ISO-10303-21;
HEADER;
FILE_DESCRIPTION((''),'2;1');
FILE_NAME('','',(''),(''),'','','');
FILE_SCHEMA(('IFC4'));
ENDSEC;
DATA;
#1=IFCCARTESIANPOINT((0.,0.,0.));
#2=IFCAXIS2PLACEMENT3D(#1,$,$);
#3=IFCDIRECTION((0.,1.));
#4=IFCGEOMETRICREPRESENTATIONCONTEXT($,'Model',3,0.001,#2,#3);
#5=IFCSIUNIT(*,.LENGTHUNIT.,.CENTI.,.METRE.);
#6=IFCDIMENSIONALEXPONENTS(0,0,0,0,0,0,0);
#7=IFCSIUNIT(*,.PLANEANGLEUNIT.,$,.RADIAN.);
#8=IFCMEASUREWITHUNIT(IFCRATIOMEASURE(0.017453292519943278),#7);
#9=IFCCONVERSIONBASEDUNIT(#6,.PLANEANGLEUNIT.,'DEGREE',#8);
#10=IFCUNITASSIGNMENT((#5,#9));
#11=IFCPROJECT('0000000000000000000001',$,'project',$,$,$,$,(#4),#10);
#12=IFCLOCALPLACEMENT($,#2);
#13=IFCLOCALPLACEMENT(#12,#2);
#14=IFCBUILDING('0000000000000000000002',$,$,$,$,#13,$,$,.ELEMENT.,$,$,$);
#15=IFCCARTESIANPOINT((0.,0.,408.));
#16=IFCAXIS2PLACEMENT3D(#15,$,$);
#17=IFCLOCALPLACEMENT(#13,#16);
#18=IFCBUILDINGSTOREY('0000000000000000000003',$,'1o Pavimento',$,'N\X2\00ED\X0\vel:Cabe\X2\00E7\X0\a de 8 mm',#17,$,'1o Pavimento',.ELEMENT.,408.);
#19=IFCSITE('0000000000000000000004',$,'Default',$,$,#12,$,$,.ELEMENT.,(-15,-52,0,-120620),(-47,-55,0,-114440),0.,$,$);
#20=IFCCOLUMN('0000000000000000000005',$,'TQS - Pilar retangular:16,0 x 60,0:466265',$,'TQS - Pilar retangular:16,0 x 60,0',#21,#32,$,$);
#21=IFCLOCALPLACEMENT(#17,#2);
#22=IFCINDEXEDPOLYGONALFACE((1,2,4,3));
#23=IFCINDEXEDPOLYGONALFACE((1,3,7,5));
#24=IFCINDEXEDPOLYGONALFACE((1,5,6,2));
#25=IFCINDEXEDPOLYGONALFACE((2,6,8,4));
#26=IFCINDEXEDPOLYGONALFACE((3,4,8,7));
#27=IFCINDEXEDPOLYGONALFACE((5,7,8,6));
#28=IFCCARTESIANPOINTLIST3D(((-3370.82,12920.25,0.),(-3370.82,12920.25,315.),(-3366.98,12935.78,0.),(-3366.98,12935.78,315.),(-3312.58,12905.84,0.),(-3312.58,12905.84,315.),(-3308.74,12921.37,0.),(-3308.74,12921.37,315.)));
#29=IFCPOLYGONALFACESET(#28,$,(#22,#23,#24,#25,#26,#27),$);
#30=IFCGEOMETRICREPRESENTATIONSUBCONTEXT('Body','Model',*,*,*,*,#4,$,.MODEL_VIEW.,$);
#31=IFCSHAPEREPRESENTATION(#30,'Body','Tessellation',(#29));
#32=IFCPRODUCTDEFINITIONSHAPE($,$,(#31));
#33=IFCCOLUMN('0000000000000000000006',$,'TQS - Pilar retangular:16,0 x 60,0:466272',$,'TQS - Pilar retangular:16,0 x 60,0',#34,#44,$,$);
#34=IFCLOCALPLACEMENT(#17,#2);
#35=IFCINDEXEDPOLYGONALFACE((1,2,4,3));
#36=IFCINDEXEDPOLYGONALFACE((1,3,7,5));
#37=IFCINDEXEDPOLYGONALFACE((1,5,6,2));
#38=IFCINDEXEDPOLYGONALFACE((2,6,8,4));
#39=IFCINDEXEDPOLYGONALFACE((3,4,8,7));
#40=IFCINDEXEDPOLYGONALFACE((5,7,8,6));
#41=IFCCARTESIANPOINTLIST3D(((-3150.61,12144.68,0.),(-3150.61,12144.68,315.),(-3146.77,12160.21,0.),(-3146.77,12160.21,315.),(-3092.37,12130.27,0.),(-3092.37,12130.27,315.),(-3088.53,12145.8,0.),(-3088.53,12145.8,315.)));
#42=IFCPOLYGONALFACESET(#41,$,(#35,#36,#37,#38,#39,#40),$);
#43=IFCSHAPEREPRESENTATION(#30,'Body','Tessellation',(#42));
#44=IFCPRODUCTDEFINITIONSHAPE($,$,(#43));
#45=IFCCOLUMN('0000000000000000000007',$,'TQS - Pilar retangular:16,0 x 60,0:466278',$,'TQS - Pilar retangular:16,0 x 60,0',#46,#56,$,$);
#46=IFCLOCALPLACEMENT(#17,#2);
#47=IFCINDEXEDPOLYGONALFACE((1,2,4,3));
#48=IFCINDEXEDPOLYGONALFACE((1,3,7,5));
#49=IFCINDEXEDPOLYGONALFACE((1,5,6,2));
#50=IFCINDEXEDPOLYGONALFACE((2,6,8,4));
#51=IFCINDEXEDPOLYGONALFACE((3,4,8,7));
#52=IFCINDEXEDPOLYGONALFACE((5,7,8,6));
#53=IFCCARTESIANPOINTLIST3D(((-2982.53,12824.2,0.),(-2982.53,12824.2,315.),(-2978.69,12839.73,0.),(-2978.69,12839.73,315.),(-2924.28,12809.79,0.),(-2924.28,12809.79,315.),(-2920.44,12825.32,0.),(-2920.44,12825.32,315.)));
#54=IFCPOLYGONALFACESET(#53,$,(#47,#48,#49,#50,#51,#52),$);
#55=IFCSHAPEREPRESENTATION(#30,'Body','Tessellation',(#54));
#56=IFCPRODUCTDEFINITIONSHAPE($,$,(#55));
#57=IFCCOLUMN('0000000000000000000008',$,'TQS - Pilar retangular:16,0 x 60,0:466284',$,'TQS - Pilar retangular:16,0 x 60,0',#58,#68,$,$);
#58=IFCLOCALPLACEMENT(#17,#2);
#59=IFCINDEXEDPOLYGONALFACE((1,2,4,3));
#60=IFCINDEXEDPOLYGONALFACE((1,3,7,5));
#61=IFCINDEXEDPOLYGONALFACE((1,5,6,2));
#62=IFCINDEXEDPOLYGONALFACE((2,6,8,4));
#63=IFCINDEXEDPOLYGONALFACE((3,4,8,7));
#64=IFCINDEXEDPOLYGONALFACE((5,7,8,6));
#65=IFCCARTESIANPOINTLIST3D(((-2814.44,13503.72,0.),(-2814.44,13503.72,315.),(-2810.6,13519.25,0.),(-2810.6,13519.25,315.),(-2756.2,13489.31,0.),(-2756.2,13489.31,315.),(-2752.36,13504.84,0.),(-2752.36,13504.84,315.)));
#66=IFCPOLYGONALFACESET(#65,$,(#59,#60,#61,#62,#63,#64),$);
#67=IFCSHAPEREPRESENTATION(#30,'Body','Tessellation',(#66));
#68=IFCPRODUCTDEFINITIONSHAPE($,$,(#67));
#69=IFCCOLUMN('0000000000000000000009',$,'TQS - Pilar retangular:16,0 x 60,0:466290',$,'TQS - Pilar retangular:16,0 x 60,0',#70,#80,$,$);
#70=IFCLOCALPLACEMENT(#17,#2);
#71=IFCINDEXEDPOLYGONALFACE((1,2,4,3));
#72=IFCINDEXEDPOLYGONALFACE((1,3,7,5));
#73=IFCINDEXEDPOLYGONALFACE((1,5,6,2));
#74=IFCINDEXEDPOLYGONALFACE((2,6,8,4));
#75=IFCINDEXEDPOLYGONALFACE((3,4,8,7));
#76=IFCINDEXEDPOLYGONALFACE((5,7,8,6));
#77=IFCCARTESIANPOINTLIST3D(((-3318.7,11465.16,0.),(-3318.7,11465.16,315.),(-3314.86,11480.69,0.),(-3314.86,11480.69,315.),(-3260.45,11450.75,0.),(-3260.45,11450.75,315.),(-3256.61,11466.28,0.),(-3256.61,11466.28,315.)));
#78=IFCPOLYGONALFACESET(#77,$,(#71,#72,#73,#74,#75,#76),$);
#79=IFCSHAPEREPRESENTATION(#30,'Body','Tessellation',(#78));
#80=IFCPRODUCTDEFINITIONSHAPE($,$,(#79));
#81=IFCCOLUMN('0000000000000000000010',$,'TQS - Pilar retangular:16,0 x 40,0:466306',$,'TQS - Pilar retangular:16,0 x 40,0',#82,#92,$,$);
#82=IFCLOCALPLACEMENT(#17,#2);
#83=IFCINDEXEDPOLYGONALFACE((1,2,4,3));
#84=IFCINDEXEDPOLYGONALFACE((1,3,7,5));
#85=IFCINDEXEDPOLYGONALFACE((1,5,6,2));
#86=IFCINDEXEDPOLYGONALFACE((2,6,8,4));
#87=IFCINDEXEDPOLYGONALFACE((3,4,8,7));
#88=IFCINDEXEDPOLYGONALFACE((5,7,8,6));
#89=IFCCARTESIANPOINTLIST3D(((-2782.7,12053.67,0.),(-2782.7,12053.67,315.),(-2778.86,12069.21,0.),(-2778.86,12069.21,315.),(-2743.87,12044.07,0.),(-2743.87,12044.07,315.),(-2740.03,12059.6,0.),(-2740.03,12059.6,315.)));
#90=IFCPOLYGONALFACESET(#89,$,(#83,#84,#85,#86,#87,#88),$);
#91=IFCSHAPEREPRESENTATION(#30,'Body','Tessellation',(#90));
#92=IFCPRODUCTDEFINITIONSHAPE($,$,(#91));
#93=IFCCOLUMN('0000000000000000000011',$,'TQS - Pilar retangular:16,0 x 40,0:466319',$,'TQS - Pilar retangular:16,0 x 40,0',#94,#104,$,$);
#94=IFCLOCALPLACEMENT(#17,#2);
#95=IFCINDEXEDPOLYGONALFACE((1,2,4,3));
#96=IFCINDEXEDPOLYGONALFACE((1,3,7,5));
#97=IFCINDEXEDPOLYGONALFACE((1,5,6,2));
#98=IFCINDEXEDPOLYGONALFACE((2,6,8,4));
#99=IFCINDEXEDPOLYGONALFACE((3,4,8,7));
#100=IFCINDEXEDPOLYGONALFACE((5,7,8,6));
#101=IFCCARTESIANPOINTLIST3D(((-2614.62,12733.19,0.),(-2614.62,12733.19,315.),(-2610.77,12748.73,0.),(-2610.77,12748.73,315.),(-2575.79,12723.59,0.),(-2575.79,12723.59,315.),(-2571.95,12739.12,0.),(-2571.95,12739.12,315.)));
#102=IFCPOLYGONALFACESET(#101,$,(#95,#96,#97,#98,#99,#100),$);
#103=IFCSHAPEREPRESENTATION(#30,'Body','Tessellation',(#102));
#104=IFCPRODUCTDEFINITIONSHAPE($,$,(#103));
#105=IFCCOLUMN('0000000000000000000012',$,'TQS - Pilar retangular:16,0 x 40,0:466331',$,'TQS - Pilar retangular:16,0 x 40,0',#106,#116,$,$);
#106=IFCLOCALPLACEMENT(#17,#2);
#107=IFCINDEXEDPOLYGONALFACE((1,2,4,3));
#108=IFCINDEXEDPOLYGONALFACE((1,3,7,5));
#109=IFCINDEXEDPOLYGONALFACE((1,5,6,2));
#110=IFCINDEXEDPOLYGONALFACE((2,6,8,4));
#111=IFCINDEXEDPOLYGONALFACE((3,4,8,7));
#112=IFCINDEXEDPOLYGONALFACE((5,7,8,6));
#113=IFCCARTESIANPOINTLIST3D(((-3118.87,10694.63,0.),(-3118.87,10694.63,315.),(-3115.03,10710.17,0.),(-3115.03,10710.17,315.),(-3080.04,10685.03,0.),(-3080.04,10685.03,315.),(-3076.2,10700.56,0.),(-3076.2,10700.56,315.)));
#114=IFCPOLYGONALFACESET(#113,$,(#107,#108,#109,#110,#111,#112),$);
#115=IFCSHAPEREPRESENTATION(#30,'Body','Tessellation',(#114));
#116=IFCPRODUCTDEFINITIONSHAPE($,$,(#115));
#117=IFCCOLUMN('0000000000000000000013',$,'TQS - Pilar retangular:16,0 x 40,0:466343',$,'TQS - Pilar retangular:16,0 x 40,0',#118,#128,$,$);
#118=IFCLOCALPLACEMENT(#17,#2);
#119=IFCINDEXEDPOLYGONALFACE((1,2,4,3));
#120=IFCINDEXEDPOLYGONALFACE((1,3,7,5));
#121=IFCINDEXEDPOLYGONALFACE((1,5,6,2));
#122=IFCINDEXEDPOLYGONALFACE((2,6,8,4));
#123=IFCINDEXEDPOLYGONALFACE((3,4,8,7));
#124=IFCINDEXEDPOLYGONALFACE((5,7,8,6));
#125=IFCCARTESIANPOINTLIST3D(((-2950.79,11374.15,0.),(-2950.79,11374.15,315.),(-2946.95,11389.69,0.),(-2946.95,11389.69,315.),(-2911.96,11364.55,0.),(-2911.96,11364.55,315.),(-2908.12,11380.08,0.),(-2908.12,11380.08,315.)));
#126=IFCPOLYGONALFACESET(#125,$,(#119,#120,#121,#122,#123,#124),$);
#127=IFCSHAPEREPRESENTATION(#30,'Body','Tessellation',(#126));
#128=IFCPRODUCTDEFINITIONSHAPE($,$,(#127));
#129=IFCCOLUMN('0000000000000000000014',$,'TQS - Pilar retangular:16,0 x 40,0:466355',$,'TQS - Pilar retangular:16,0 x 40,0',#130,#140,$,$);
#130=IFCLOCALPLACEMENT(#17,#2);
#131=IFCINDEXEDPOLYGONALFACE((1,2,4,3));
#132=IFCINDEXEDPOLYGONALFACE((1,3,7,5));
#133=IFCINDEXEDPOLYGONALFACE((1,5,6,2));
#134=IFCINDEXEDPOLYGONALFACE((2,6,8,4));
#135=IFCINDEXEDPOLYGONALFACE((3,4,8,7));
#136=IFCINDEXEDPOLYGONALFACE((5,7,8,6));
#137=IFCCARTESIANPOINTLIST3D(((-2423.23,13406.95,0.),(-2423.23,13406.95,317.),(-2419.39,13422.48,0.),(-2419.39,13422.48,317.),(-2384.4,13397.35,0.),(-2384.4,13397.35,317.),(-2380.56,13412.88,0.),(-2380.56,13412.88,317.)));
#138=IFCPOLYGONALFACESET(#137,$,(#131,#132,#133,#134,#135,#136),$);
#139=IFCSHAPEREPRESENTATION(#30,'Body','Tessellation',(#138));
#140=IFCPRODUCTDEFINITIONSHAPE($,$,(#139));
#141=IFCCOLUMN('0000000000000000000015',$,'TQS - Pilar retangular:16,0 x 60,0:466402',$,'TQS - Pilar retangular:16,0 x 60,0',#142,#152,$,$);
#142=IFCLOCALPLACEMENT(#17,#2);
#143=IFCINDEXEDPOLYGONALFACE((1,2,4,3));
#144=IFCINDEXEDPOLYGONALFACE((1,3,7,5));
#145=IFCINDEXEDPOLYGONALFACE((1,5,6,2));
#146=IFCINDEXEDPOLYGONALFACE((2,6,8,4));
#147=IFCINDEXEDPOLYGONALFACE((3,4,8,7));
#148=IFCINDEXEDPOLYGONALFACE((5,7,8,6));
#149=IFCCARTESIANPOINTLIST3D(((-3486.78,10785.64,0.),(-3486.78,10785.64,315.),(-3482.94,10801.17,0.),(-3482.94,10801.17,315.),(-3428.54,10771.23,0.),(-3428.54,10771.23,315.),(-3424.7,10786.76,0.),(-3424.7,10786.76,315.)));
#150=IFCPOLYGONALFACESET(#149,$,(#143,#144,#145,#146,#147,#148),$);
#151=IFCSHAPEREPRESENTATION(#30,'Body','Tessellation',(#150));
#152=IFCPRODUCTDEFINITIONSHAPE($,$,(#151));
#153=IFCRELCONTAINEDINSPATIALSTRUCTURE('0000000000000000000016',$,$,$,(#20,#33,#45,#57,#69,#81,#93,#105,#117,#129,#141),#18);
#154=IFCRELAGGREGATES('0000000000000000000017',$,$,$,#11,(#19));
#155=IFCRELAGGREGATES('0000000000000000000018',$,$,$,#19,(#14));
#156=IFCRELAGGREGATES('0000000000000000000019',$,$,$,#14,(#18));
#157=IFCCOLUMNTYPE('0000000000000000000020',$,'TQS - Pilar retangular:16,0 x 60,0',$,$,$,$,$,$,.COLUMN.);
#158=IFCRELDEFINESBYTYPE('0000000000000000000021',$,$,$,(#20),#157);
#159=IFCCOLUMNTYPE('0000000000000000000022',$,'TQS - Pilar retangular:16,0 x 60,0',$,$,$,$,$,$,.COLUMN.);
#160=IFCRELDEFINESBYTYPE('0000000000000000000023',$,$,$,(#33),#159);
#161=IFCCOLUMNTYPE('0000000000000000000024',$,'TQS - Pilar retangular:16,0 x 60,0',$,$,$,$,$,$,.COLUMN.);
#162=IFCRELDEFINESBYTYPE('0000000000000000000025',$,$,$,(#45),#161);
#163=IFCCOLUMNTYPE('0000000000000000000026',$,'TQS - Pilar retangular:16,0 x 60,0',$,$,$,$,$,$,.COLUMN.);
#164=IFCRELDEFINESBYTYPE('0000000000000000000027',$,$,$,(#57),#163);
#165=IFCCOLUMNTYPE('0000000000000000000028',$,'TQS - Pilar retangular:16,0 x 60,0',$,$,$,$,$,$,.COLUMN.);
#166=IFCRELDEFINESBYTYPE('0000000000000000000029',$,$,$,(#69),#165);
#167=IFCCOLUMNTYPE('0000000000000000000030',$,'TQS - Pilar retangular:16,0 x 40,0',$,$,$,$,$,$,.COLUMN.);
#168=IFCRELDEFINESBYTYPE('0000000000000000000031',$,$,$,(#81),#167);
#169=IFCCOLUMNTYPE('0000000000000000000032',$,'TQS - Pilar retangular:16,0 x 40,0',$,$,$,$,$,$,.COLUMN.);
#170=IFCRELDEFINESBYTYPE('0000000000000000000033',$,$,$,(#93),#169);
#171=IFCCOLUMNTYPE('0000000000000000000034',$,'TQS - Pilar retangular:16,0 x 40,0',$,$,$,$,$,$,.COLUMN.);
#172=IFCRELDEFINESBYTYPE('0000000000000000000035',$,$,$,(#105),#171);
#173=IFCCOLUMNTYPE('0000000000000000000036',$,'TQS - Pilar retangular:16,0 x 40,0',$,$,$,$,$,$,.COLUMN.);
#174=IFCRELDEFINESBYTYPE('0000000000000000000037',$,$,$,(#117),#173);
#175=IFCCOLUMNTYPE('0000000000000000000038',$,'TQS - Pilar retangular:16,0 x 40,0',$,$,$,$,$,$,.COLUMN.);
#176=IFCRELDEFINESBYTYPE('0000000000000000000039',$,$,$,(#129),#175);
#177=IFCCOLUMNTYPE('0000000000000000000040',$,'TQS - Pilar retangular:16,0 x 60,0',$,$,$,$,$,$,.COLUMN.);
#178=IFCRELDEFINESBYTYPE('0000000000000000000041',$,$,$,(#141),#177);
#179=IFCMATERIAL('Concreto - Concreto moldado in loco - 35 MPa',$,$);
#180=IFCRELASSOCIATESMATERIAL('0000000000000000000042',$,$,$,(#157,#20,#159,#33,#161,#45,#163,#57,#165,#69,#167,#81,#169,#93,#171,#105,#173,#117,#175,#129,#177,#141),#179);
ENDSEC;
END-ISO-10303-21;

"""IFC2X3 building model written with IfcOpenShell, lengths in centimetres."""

from ifc_helpers import new_model, entity, si_unit, converted_unit, direction, frame, origin, origin_2d_with_axis, place, context, subcontext, project, spatial, rectangle, extrude, source, transform, mapped, material, type_object, type_shapes, element, save


model = new_model("IFC2X3")

# Units and contexts
model_context = context("Model", 3, precision=0.001, world=origin(), true_north=direction((0.0, 1.0)))
body_context = subcontext(model_context, "Body", "Model", "MODEL_VIEW")
ifc_project = project(units=[si_unit("LENGTHUNIT", "METRE", prefix="CENTI"), converted_unit("PLANEANGLEUNIT", "DEGREE", entity("IfcRatioMeasure", 0.017453292519943278), si_unit("PLANEANGLEUNIT", "RADIAN"), dimensions=[0, 0, 0, 0, 0, 0, 0])], contexts=[model_context])

# Site, building, storey
site_placement = place(None, origin())
site = spatial("IfcSite", under=ifc_project, at=site_placement, Name="Default", CompositionType="ELEMENT", RefLatitude=(-15, -52, 0, -120620), RefLongitude=(-47, -55, 0, -114440), RefElevation=0.0)
building_placement = place(site_placement, origin())
building = spatial("IfcBuilding", under=site, at=building_placement, CompositionType="ELEMENT")
storey_placement = place(building_placement, frame((0.0, 0.0, 408.0)))
storey = spatial("IfcBuildingStorey", under=building, at=storey_placement, Name="1o Pavimento", ObjectType="Nível:Cabeça de 8 mm", LongName="1o Pavimento", CompositionType="ELEMENT", Elevation=408.0)

# Columns
ifc_material = material(Name="Concreto - Concreto moldado in loco - 35 MPa")
column_type_1 = type_object("IfcColumnType", Name="TQS - Pilar retangular:16,0 x 60,0", PredefinedType="COLUMN", material=ifc_material)
shared_shape_1 = source(origin(), body_context, "Body", "SweptSolid", [
    extrude(rectangle(XDim=60.0, YDim=16.0, at=origin_2d_with_axis()), frame((-3339.78, 12920.81, 408.0), z_axis=(0.0, 0.0, 1.0), x_axis=(-0.970743, 0.240122, 0.0)), (0.0, 0.0, 1.0), 315.0),
])
type_shapes(column_type_1, [shared_shape_1])
column_1_placement = place(storey_placement, frame((0.0, 0.0, -408.0)))
element("IfcColumn", 1, at=column_1_placement, inside=storey, type_object=column_type_1, material=ifc_material, Name="TQS - Pilar retangular:16,0 x 60,0:466265", ObjectType="TQS - Pilar retangular:16,0 x 60,0", context=body_context, shape_type="MappedRepresentation", body=[
    mapped(shared_shape_1, transform((0.0, 0.0, 0.0), scale=1.0)),
])
column_type_2 = type_object("IfcColumnType", Name="TQS - Pilar retangular:16,0 x 60,0", PredefinedType="COLUMN", material=ifc_material)
shared_shape_2 = source(origin(), body_context, "Body", "SweptSolid", [
    extrude(rectangle(XDim=60.0, YDim=16.0, at=origin_2d_with_axis()), frame((-3119.57, 12145.24, 408.0), z_axis=(0.0, 0.0, 1.0), x_axis=(-0.970743, 0.240122, 0.0)), (0.0, 0.0, 1.0), 315.0),
])
type_shapes(column_type_2, [shared_shape_2])
column_2_placement = place(storey_placement, frame((0.0, 0.0, -408.0)))
element("IfcColumn", 2, at=column_2_placement, inside=storey, type_object=column_type_2, material=ifc_material, Name="TQS - Pilar retangular:16,0 x 60,0:466272", ObjectType="TQS - Pilar retangular:16,0 x 60,0", context=body_context, shape_type="MappedRepresentation", body=[
    mapped(shared_shape_2, transform((0.0, 0.0, 0.0), scale=1.0)),
])
column_type_3 = type_object("IfcColumnType", Name="TQS - Pilar retangular:16,0 x 60,0", PredefinedType="COLUMN", material=ifc_material)
shared_shape_3 = source(origin(), body_context, "Body", "SweptSolid", [
    extrude(rectangle(XDim=60.0, YDim=16.0, at=origin_2d_with_axis()), frame((-2951.48, 12824.76, 408.0), z_axis=(0.0, 0.0, 1.0), x_axis=(-0.970743, 0.240122, 0.0)), (0.0, 0.0, 1.0), 315.0),
])
type_shapes(column_type_3, [shared_shape_3])
column_3_placement = place(storey_placement, frame((0.0, 0.0, -408.0)))
element("IfcColumn", 3, at=column_3_placement, inside=storey, type_object=column_type_3, material=ifc_material, Name="TQS - Pilar retangular:16,0 x 60,0:466278", ObjectType="TQS - Pilar retangular:16,0 x 60,0", context=body_context, shape_type="MappedRepresentation", body=[
    mapped(shared_shape_3, transform((0.0, 0.0, 0.0), scale=1.0)),
])
column_type_4 = type_object("IfcColumnType", Name="TQS - Pilar retangular:16,0 x 60,0", PredefinedType="COLUMN", material=ifc_material)
shared_shape_4 = source(origin(), body_context, "Body", "SweptSolid", [
    extrude(rectangle(XDim=60.0, YDim=16.0, at=origin_2d_with_axis()), frame((-2783.4, 13504.28, 408.0), z_axis=(0.0, 0.0, 1.0), x_axis=(-0.970743, 0.240122, 0.0)), (0.0, 0.0, 1.0), 315.0),
])
type_shapes(column_type_4, [shared_shape_4])
column_4_placement = place(storey_placement, frame((0.0, 0.0, -408.0)))
element("IfcColumn", 4, at=column_4_placement, inside=storey, type_object=column_type_4, material=ifc_material, Name="TQS - Pilar retangular:16,0 x 60,0:466284", ObjectType="TQS - Pilar retangular:16,0 x 60,0", context=body_context, shape_type="MappedRepresentation", body=[
    mapped(shared_shape_4, transform((0.0, 0.0, 0.0), scale=1.0)),
])
column_type_5 = type_object("IfcColumnType", Name="TQS - Pilar retangular:16,0 x 60,0", PredefinedType="COLUMN", material=ifc_material)
shared_shape_5 = source(origin(), body_context, "Body", "SweptSolid", [
    extrude(rectangle(XDim=60.0, YDim=16.0, at=origin_2d_with_axis()), frame((-3287.66, 11465.72, 408.0), z_axis=(0.0, 0.0, 1.0), x_axis=(-0.970743, 0.240122, 0.0)), (0.0, 0.0, 1.0), 315.0),
])
type_shapes(column_type_5, [shared_shape_5])
column_5_placement = place(storey_placement, frame((0.0, 0.0, -408.0)))
element("IfcColumn", 5, at=column_5_placement, inside=storey, type_object=column_type_5, material=ifc_material, Name="TQS - Pilar retangular:16,0 x 60,0:466290", ObjectType="TQS - Pilar retangular:16,0 x 60,0", context=body_context, shape_type="MappedRepresentation", body=[
    mapped(shared_shape_5, transform((0.0, 0.0, 0.0), scale=1.0)),
])
column_type_6 = type_object("IfcColumnType", Name="TQS - Pilar retangular:16,0 x 40,0", PredefinedType="COLUMN", material=ifc_material)
shared_shape_6 = source(origin(), body_context, "Body", "SweptSolid", [
    extrude(rectangle(XDim=40.0, YDim=16.0, at=origin_2d_with_axis()), frame((-2761.37, 12056.64, 408.0), z_axis=(0.0, 0.0, 1.0), x_axis=(-0.970743, 0.240122, 0.0)), (0.0, 0.0, 1.0), 315.0),
])
type_shapes(column_type_6, [shared_shape_6])
column_6_placement = place(storey_placement, frame((0.0, 0.0, -408.0)))
element("IfcColumn", 6, at=column_6_placement, inside=storey, type_object=column_type_6, material=ifc_material, Name="TQS - Pilar retangular:16,0 x 40,0:466306", ObjectType="TQS - Pilar retangular:16,0 x 40,0", context=body_context, shape_type="MappedRepresentation", body=[
    mapped(shared_shape_6, transform((0.0, 0.0, 0.0), scale=1.0)),
])
column_type_7 = type_object("IfcColumnType", Name="TQS - Pilar retangular:16,0 x 40,0", PredefinedType="COLUMN", material=ifc_material)
shared_shape_7 = source(origin(), body_context, "Body", "SweptSolid", [
    extrude(rectangle(XDim=40.0, YDim=16.0, at=origin_2d_with_axis()), frame((-2593.28, 12736.16, 408.0), z_axis=(0.0, 0.0, 1.0), x_axis=(-0.970743, 0.240122, 0.0)), (0.0, 0.0, 1.0), 315.0),
])
type_shapes(column_type_7, [shared_shape_7])
column_7_placement = place(storey_placement, frame((0.0, 0.0, -408.0)))
element("IfcColumn", 7, at=column_7_placement, inside=storey, type_object=column_type_7, material=ifc_material, Name="TQS - Pilar retangular:16,0 x 40,0:466319", ObjectType="TQS - Pilar retangular:16,0 x 40,0", context=body_context, shape_type="MappedRepresentation", body=[
    mapped(shared_shape_7, transform((0.0, 0.0, 0.0), scale=1.0)),
])
column_type_8 = type_object("IfcColumnType", Name="TQS - Pilar retangular:16,0 x 40,0", PredefinedType="COLUMN", material=ifc_material)
shared_shape_8 = source(origin(), body_context, "Body", "SweptSolid", [
    extrude(rectangle(XDim=40.0, YDim=16.0, at=origin_2d_with_axis()), frame((-3097.54, 10697.6, 408.0), z_axis=(0.0, 0.0, 1.0), x_axis=(-0.970743, 0.240122, 0.0)), (0.0, 0.0, 1.0), 315.0),
])
type_shapes(column_type_8, [shared_shape_8])
column_8_placement = place(storey_placement, frame((0.0, 0.0, -408.0)))
element("IfcColumn", 8, at=column_8_placement, inside=storey, type_object=column_type_8, material=ifc_material, Name="TQS - Pilar retangular:16,0 x 40,0:466331", ObjectType="TQS - Pilar retangular:16,0 x 40,0", context=body_context, shape_type="MappedRepresentation", body=[
    mapped(shared_shape_8, transform((0.0, 0.0, 0.0), scale=1.0)),
])
column_type_9 = type_object("IfcColumnType", Name="TQS - Pilar retangular:16,0 x 40,0", PredefinedType="COLUMN", material=ifc_material)
shared_shape_9 = source(origin(), body_context, "Body", "SweptSolid", [
    extrude(rectangle(XDim=40.0, YDim=16.0, at=origin_2d_with_axis()), frame((-2929.45, 11377.12, 408.0), z_axis=(0.0, 0.0, 1.0), x_axis=(-0.970743, 0.240122, 0.0)), (0.0, 0.0, 1.0), 315.0),
])
type_shapes(column_type_9, [shared_shape_9])
column_9_placement = place(storey_placement, frame((0.0, 0.0, -408.0)))
element("IfcColumn", 9, at=column_9_placement, inside=storey, type_object=column_type_9, material=ifc_material, Name="TQS - Pilar retangular:16,0 x 40,0:466343", ObjectType="TQS - Pilar retangular:16,0 x 40,0", context=body_context, shape_type="MappedRepresentation", body=[
    mapped(shared_shape_9, transform((0.0, 0.0, 0.0), scale=1.0)),
])
column_type_10 = type_object("IfcColumnType", Name="TQS - Pilar retangular:16,0 x 40,0", PredefinedType="COLUMN", material=ifc_material)
shared_shape_10 = source(origin(), body_context, "Body", "SweptSolid", [
    extrude(rectangle(XDim=40.0, YDim=16.0, at=origin_2d_with_axis()), frame((-2401.9, 13409.91, 408.0), z_axis=(0.0, 0.0, 1.0), x_axis=(-0.970743, 0.240122, 0.0)), (0.0, 0.0, 1.0), 317.0),
])
type_shapes(column_type_10, [shared_shape_10])
column_10_placement = place(storey_placement, frame((0.0, 0.0, -408.0)))
element("IfcColumn", 10, at=column_10_placement, inside=storey, type_object=column_type_10, material=ifc_material, Name="TQS - Pilar retangular:16,0 x 40,0:466355", ObjectType="TQS - Pilar retangular:16,0 x 40,0", context=body_context, shape_type="MappedRepresentation", body=[
    mapped(shared_shape_10, transform((0.0, 0.0, 0.0), scale=1.0)),
])
column_type_11 = type_object("IfcColumnType", Name="TQS - Pilar retangular:16,0 x 60,0", PredefinedType="COLUMN", material=ifc_material)
shared_shape_11 = source(origin(), body_context, "Body", "SweptSolid", [
    extrude(rectangle(XDim=60.0, YDim=16.0, at=origin_2d_with_axis()), frame((-3455.74, 10786.2, 408.0), z_axis=(0.0, 0.0, 1.0), x_axis=(-0.970743, 0.240122, 0.0)), (0.0, 0.0, 1.0), 315.0),
])
type_shapes(column_type_11, [shared_shape_11])
column_11_placement = place(storey_placement, frame((0.0, 0.0, -408.0)))
element("IfcColumn", 11, at=column_11_placement, inside=storey, type_object=column_type_11, material=ifc_material, Name="TQS - Pilar retangular:16,0 x 60,0:466402", ObjectType="TQS - Pilar retangular:16,0 x 60,0", context=body_context, shape_type="MappedRepresentation", body=[
    mapped(shared_shape_11, transform((0.0, 0.0, 0.0), scale=1.0)),
])

save(model, "model.ifc")
